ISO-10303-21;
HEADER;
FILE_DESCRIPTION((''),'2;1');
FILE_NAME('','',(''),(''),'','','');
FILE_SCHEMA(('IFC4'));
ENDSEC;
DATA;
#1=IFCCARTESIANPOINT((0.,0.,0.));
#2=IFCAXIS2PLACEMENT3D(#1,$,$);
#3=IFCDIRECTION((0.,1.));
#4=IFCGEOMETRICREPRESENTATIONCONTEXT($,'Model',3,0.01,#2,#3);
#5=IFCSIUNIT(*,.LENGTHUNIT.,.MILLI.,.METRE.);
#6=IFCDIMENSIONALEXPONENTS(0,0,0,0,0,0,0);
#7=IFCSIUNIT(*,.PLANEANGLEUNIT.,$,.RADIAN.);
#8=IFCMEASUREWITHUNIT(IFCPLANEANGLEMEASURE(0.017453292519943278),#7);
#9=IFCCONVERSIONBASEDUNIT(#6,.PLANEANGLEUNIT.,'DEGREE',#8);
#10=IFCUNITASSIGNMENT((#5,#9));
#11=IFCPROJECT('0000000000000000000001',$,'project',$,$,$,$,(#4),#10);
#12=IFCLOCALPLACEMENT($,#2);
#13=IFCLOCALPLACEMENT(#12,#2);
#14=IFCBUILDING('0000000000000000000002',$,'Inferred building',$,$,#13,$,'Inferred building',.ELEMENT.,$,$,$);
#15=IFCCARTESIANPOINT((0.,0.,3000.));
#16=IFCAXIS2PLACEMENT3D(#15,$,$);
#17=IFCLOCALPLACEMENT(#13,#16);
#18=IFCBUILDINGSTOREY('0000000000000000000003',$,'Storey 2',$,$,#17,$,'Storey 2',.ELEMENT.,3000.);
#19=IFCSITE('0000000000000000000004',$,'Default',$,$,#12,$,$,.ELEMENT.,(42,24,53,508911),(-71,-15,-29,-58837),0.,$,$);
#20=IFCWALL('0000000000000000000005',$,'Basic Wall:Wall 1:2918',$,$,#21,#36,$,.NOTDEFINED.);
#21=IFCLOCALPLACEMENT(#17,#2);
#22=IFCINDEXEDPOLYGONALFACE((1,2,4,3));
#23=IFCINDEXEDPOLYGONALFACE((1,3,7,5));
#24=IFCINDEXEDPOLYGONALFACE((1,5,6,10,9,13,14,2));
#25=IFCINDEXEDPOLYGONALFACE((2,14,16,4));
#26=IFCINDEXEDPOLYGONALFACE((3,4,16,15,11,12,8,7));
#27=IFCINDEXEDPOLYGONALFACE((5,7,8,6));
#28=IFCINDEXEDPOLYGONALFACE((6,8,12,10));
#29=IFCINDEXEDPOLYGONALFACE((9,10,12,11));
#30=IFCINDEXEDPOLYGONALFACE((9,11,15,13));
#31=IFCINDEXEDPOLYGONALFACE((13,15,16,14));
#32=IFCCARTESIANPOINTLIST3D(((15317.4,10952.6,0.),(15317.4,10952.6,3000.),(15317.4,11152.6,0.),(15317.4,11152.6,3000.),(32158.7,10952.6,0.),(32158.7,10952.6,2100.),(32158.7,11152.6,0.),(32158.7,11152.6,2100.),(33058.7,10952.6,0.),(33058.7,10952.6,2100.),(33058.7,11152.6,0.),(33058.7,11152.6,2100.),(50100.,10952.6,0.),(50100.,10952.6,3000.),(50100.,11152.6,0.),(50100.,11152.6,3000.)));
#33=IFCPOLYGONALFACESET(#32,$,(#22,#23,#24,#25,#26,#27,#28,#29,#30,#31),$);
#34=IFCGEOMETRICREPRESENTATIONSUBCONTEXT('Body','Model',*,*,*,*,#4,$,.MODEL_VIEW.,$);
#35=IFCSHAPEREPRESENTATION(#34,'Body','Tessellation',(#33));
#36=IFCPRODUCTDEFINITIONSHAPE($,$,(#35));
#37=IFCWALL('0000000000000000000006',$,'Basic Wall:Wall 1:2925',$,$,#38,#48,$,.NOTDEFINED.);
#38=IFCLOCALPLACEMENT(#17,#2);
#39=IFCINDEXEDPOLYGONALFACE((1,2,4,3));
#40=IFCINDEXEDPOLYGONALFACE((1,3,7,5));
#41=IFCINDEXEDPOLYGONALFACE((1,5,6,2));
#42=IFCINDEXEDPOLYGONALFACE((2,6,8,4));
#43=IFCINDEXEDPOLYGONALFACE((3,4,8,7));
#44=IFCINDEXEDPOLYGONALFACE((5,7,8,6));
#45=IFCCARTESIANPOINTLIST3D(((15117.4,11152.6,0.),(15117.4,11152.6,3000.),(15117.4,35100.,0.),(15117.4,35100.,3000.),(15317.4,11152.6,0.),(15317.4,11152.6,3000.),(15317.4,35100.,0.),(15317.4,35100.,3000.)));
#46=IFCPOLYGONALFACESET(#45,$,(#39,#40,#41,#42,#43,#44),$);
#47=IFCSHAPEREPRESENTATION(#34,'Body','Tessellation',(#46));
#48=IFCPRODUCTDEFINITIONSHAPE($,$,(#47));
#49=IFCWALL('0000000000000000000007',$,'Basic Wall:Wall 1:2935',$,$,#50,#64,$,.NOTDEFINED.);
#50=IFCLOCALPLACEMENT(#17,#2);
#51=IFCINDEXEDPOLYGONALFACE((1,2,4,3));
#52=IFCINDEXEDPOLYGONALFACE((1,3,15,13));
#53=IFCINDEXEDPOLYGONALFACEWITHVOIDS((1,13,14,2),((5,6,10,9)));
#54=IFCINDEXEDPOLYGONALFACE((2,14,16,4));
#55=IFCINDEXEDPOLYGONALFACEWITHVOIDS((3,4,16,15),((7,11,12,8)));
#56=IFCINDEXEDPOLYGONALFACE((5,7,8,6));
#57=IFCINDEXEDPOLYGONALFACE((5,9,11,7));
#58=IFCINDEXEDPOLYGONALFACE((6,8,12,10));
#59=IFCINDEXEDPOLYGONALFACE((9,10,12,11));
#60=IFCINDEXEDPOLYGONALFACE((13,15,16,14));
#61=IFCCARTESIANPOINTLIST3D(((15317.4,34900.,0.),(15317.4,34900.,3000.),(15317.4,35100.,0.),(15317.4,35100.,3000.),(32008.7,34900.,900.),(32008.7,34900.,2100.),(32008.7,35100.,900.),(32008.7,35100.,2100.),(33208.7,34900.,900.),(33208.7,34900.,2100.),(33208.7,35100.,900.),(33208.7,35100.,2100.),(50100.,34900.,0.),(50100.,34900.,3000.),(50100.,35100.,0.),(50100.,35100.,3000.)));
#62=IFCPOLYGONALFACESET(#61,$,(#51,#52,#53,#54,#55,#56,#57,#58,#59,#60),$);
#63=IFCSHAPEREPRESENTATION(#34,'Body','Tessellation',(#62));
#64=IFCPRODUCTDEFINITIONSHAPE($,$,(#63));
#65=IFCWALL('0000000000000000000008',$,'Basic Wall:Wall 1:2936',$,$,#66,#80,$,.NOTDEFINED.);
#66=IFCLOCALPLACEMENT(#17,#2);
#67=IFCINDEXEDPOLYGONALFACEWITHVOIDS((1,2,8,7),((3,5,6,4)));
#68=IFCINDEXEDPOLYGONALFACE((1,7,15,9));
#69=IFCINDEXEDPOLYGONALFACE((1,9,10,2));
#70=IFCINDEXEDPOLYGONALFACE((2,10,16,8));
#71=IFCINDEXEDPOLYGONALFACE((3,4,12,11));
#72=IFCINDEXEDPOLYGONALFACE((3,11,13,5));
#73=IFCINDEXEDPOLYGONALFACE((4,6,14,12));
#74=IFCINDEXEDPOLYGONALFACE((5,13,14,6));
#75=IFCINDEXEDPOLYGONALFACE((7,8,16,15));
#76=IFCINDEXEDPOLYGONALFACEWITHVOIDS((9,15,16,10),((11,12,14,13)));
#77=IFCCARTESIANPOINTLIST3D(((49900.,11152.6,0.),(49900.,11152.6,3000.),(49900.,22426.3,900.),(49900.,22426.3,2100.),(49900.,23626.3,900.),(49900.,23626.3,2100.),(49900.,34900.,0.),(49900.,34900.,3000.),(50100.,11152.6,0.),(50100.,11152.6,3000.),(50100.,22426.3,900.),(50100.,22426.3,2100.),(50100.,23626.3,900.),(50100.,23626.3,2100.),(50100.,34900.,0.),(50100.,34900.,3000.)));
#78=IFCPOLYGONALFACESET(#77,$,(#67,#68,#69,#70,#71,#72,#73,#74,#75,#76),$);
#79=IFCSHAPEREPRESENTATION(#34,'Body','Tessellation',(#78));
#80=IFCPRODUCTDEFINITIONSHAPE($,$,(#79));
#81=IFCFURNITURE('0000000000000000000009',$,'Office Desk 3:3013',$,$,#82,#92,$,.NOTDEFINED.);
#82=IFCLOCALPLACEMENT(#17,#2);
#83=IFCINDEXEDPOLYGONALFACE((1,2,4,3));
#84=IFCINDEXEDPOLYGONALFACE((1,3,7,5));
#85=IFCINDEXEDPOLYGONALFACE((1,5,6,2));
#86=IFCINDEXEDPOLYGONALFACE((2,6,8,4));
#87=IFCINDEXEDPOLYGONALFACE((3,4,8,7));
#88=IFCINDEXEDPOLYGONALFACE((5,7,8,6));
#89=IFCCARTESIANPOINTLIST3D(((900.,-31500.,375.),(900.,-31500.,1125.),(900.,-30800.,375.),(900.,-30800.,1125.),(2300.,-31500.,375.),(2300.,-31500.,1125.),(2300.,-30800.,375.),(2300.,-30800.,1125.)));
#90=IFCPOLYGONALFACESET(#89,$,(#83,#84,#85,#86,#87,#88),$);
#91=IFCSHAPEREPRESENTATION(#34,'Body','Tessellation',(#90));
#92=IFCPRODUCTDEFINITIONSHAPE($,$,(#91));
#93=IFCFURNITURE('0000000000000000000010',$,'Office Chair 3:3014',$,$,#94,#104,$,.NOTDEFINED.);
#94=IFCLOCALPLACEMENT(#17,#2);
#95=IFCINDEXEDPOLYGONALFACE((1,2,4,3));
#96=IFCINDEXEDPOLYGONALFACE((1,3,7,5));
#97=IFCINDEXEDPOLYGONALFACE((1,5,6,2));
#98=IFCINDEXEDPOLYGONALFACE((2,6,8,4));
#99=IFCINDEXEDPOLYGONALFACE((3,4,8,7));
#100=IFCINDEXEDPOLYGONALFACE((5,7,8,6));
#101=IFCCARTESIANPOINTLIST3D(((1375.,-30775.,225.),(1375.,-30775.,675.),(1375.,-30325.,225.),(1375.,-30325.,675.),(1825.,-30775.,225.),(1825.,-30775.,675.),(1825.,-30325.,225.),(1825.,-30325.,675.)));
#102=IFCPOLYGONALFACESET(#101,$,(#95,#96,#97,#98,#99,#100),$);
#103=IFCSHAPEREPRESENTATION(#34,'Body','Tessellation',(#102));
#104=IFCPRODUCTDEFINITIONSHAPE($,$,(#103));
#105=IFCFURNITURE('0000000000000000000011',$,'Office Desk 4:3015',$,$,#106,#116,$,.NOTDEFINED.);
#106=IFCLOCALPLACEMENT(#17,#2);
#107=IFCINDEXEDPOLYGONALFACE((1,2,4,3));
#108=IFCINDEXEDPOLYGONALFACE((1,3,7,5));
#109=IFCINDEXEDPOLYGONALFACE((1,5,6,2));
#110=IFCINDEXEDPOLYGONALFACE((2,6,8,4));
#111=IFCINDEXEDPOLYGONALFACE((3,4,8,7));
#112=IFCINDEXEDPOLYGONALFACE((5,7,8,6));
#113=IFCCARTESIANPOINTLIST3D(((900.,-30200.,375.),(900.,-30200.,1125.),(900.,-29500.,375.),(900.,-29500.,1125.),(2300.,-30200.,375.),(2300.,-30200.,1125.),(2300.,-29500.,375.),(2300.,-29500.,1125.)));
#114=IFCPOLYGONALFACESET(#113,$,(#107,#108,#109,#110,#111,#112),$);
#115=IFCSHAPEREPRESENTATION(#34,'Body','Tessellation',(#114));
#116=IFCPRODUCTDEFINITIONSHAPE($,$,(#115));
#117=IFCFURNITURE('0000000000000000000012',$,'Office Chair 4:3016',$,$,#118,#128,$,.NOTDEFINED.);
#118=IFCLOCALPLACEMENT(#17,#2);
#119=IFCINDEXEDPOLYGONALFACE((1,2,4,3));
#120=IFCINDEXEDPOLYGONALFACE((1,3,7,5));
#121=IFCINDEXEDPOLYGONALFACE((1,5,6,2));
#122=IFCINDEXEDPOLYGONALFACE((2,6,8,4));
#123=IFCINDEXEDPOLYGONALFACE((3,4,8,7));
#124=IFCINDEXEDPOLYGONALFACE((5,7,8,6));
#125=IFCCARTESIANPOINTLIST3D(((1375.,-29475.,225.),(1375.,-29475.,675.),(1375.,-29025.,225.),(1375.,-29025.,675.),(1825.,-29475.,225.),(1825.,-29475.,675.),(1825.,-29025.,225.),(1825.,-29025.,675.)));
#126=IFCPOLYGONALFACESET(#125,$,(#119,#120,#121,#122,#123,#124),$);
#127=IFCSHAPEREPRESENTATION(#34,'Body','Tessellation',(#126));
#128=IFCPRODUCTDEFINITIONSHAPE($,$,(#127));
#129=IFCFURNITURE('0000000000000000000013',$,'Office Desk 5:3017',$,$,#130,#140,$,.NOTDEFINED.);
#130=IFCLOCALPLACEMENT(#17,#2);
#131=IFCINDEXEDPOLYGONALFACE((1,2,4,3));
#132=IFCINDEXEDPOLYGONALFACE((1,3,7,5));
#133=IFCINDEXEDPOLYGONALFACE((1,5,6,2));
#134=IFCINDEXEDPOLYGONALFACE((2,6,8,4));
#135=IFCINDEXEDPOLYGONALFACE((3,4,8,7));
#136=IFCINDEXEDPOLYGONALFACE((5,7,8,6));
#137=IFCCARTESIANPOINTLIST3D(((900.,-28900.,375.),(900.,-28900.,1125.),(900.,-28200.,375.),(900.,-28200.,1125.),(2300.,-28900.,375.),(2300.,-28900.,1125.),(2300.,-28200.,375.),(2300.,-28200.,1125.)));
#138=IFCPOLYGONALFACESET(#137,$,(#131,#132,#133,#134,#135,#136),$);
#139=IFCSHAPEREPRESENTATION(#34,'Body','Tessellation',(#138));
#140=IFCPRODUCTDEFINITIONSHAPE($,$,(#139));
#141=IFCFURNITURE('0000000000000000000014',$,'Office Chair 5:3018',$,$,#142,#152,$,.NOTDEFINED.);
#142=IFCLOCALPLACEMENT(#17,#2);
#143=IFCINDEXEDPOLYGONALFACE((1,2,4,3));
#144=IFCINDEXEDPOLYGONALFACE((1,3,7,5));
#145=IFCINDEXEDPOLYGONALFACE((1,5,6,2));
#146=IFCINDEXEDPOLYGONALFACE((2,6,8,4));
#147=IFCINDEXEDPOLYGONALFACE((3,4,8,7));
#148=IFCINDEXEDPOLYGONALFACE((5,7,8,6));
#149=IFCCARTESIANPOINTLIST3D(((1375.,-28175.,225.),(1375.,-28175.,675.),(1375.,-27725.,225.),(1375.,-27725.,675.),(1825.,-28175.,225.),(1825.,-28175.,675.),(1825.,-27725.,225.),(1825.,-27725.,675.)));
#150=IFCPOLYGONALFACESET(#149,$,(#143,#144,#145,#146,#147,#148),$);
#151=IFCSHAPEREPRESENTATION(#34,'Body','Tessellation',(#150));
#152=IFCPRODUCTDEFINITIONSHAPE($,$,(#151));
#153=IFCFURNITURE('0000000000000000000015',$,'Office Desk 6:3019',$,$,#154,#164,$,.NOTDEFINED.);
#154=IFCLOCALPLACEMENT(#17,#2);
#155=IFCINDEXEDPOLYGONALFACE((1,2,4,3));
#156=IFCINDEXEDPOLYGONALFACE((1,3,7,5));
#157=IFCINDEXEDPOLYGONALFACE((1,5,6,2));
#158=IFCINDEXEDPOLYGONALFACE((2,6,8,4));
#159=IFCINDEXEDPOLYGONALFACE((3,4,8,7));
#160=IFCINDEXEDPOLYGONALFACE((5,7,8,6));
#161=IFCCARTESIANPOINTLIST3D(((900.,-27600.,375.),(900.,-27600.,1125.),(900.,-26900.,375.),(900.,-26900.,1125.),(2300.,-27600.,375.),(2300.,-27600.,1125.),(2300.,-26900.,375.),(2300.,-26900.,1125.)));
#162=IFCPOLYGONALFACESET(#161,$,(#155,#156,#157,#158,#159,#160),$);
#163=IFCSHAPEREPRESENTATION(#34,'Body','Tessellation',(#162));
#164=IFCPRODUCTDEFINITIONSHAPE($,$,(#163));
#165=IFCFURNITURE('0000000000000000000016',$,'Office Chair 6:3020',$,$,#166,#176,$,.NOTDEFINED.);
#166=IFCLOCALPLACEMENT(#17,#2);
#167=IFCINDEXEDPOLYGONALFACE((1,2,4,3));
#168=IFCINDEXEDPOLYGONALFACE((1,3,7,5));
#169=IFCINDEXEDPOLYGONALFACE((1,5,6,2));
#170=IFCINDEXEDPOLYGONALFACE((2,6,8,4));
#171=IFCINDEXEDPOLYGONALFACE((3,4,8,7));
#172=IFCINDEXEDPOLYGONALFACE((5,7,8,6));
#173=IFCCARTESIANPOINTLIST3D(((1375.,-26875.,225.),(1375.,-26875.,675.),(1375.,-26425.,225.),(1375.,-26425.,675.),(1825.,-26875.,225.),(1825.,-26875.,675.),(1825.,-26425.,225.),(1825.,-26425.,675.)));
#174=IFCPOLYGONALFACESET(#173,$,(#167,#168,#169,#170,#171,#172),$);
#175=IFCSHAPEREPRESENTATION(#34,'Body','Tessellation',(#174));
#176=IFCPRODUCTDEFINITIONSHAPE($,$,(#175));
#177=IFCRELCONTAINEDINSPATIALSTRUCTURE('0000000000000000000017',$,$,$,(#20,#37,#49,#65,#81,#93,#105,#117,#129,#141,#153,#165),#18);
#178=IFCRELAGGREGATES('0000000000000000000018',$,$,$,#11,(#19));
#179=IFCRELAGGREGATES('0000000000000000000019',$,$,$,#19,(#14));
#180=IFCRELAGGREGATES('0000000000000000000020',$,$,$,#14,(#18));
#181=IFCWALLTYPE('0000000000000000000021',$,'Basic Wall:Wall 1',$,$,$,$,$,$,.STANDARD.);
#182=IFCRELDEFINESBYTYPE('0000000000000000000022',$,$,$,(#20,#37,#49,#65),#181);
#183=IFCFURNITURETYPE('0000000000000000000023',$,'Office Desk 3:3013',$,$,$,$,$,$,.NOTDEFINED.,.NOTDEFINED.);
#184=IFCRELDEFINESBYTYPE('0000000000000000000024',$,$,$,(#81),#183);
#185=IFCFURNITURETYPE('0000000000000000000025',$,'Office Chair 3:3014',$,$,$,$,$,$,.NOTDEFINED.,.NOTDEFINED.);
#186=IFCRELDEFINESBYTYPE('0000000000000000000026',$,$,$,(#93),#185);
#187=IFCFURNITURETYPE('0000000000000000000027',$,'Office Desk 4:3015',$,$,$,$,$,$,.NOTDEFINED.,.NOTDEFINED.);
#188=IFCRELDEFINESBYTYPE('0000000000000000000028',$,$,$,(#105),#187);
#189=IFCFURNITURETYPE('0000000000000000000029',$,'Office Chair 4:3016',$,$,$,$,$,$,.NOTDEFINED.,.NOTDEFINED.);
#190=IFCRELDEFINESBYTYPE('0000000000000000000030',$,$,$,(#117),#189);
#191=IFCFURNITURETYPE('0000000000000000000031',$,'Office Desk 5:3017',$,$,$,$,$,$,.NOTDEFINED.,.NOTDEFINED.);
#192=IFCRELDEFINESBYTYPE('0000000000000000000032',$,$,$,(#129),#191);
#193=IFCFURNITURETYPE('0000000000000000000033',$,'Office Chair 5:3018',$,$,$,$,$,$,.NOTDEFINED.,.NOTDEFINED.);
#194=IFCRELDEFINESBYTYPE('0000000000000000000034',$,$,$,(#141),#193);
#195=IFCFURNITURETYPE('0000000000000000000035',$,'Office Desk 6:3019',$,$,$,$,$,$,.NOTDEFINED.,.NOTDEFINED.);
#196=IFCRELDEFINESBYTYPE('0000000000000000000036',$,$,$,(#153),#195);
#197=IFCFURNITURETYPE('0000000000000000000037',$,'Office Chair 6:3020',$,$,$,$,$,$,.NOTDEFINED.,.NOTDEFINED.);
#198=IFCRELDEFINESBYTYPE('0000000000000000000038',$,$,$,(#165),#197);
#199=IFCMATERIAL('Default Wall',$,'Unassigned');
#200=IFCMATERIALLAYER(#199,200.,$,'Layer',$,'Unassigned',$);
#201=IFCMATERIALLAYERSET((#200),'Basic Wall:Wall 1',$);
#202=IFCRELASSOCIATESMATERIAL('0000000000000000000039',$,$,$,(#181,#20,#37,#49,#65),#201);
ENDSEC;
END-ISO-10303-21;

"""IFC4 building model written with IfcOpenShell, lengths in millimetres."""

from ifc_helpers import new_model, entity, si_unit, converted_unit, direction, frame, frame_2d, origin, origin_2d_with_axis, place, context, subcontext, project, spatial, rectangle, extrude, material, layer, layer_set, layer_usage, type_object, element, save


model = new_model("IFC4")

# Units and contexts
model_context = context("Model", 3, precision=0.01, world=origin(), true_north=direction((0.0, 1.0)))
body_context = subcontext(model_context, "Body", "Model", "MODEL_VIEW")
ifc_project = project(units=[si_unit("LENGTHUNIT", "METRE", prefix="MILLI"), converted_unit("PLANEANGLEUNIT", "DEGREE", entity("IfcPlaneAngleMeasure", 0.017453292519943278), si_unit("PLANEANGLEUNIT", "RADIAN"), dimensions=[0, 0, 0, 0, 0, 0, 0])], contexts=[model_context])

# Site, building, storey
site_placement = place(None, origin())
site = spatial("IfcSite", under=ifc_project, at=site_placement, Name="Default", CompositionType="ELEMENT", RefLatitude=(42, 24, 53, 508911), RefLongitude=(-71, -15, -29, -58837), RefElevation=0.0)
building_placement = place(site_placement, origin())
building = spatial("IfcBuilding", under=site, at=building_placement, Name="Inferred building", LongName="Inferred building", CompositionType="ELEMENT")
storey_placement = place(building_placement, frame((0.0, 0.0, 3000.0)))
storey = spatial("IfcBuildingStorey", under=building, at=storey_placement, Name="Storey 2", LongName="Storey 2", CompositionType="ELEMENT", Elevation=3000.0)

# Wall, opening
ifc_material = material(Name="Default Wall", Category="Unassigned")
ifc_layer = layer(ifc_material, 200.0, Name="Layer", Category="Unassigned")
ifc_layer_set = layer_set([ifc_layer], Name="Basic Wall:Wall 1")
ifc_layer_usage_1 = layer_usage(ifc_layer_set, "AXIS2", "NEGATIVE", 100.0)
wall_type = type_object("IfcWallType", Name="Basic Wall:Wall 1", PredefinedType="STANDARD", material=ifc_layer_set)
wall_1_placement = place(storey_placement, frame((15317.4, 11052.6, 0.0)))
wall_1 = element("IfcWall", 1, at=wall_1_placement, inside=storey, type_object=wall_type, material=ifc_layer_usage_1, Name="Basic Wall:Wall 1:2918", PredefinedType="NOTDEFINED", context=body_context, shape_type="SweptSolid", body=[
    extrude(rectangle(XDim=34782.6, YDim=200.0, at=frame_2d((17391.3, 0.0), x_axis=(1.0, 0.0))), origin(), (0.0, 0.0, 1.0), 3000.0),
])
opening_1_placement = place(wall_1_placement, origin())
element("IfcOpeningElement", 2, at=opening_1_placement, cuts=wall_1, PredefinedType="OPENING", context=body_context, shape_type="SweptSolid", body=[
    extrude(rectangle(XDim=2100.0, YDim=900.0, at=frame_2d((0.0, 0.0), x_axis=(1.0, 0.0))), frame((17291.3, -100.0, 1050.0), z_axis=(0.0, 1.0, 0.0), x_axis=(0.0, 0.0, -1.0)), (0.0, 0.0, 1.0), 200.0),
])

# Wall
ifc_layer_usage_2 = layer_usage(ifc_layer_set, "AXIS2", "NEGATIVE", 100.0)
wall_2_placement = place(storey_placement, frame((15217.4, 11152.6, 0.0), z_axis=(0.0, 0.0, 1.0), x_axis=(0.0, 1.0, 0.0)))
element("IfcWall", 3, at=wall_2_placement, inside=storey, type_object=wall_type, material=ifc_layer_usage_2, Name="Basic Wall:Wall 1:2925", PredefinedType="NOTDEFINED", context=body_context, shape_type="SweptSolid", body=[
    extrude(rectangle(XDim=23947.4, YDim=200.0, at=frame_2d((11973.7, 0.0), x_axis=(-1.0, 0.0))), origin(), (0.0, 0.0, 1.0), 3000.0),
])

# Walls, openings
ifc_layer_usage_3 = layer_usage(ifc_layer_set, "AXIS2", "NEGATIVE", 100.0)
wall_3_placement = place(storey_placement, frame((15317.4, 35000.0, 0.0)))
wall_3 = element("IfcWall", 4, at=wall_3_placement, inside=storey, type_object=wall_type, material=ifc_layer_usage_3, Name="Basic Wall:Wall 1:2935", PredefinedType="NOTDEFINED", context=body_context, shape_type="SweptSolid", body=[
    extrude(rectangle(XDim=34782.6, YDim=200.0, at=frame_2d((17391.3, 0.0), x_axis=(-1.0, 0.0))), origin(), (0.0, 0.0, 1.0), 3000.0),
])
opening_2_placement = place(wall_3_placement, origin())
element("IfcOpeningElement", 5, at=opening_2_placement, cuts=wall_3, PredefinedType="OPENING", context=body_context, shape_type="SweptSolid", body=[
    extrude(rectangle(XDim=1200.0, YDim=1200.0, at=frame_2d((0.0, 0.0), x_axis=(1.0, 0.0))), frame((17291.3, -100.0, 1500.0), z_axis=(0.0, 1.0, 0.0), x_axis=(0.0, 0.0, -1.0)), (0.0, 0.0, 1.0), 200.0),
])
ifc_layer_usage_4 = layer_usage(ifc_layer_set, "AXIS2", "NEGATIVE", 100.0)
wall_4_placement = place(storey_placement, frame((50000.0, 11152.6, 0.0), z_axis=(0.0, 0.0, 1.0), x_axis=(0.0, 1.0, 0.0)))
wall_4 = element("IfcWall", 6, at=wall_4_placement, inside=storey, type_object=wall_type, material=ifc_layer_usage_4, Name="Basic Wall:Wall 1:2936", PredefinedType="NOTDEFINED", context=body_context, shape_type="SweptSolid", body=[
    extrude(rectangle(XDim=23747.4, YDim=200.0, at=frame_2d((11873.7, 0.0), x_axis=(-1.0, 0.0))), origin(), (0.0, 0.0, 1.0), 3000.0),
])
opening_3_placement = place(wall_4_placement, origin())
element("IfcOpeningElement", 7, at=opening_3_placement, cuts=wall_4, PredefinedType="OPENING", context=body_context, shape_type="SweptSolid", body=[
    extrude(rectangle(XDim=1200.0, YDim=1200.0, at=frame_2d((0.0, 0.0), x_axis=(1.0, 0.0))), frame((11873.7, -100.0, 1500.0), z_axis=(0.0, 1.0, 0.0), x_axis=(0.0, 0.0, -1.0)), (0.0, 0.0, 1.0), 200.0),
])

# Furniture
furniture_type_1 = type_object("IfcFurnitureType", Name="Office Desk 3:3013", PredefinedType="NOTDEFINED")
furniture_1_placement = place(storey_placement, origin())
element("IfcFurniture", 8, at=furniture_1_placement, inside=storey, type_object=furniture_type_1, Name="Office Desk 3:3013", PredefinedType="NOTDEFINED", context=body_context, shape_type="SweptSolid", body=[
    extrude(rectangle(XDim=1400.0, YDim=700.0, at=origin_2d_with_axis()), frame((1600.0, -31150.0, 375.0)), (0.0, 0.0, 1.0), 750.0),
])
furniture_type_2 = type_object("IfcFurnitureType", Name="Office Chair 3:3014", PredefinedType="NOTDEFINED")
furniture_2_placement = place(storey_placement, origin())
element("IfcFurniture", 9, at=furniture_2_placement, inside=storey, type_object=furniture_type_2, Name="Office Chair 3:3014", PredefinedType="NOTDEFINED", context=body_context, shape_type="SweptSolid", body=[
    extrude(rectangle(XDim=450.0, YDim=450.0, at=origin_2d_with_axis()), frame((1600.0, -30550.0, 225.0)), (0.0, 0.0, 1.0), 450.0),
])
furniture_type_3 = type_object("IfcFurnitureType", Name="Office Desk 4:3015", PredefinedType="NOTDEFINED")
furniture_3_placement = place(storey_placement, origin())
element("IfcFurniture", 10, at=furniture_3_placement, inside=storey, type_object=furniture_type_3, Name="Office Desk 4:3015", PredefinedType="NOTDEFINED", context=body_context, shape_type="SweptSolid", body=[
    extrude(rectangle(XDim=1400.0, YDim=700.0, at=origin_2d_with_axis()), frame((1600.0, -29850.0, 375.0)), (0.0, 0.0, 1.0), 750.0),
])
furniture_type_4 = type_object("IfcFurnitureType", Name="Office Chair 4:3016", PredefinedType="NOTDEFINED")
furniture_4_placement = place(storey_placement, origin())
element("IfcFurniture", 11, at=furniture_4_placement, inside=storey, type_object=furniture_type_4, Name="Office Chair 4:3016", PredefinedType="NOTDEFINED", context=body_context, shape_type="SweptSolid", body=[
    extrude(rectangle(XDim=450.0, YDim=450.0, at=origin_2d_with_axis()), frame((1600.0, -29250.0, 225.0)), (0.0, 0.0, 1.0), 450.0),
])
furniture_type_5 = type_object("IfcFurnitureType", Name="Office Desk 5:3017", PredefinedType="NOTDEFINED")
furniture_5_placement = place(storey_placement, origin())
element("IfcFurniture", 12, at=furniture_5_placement, inside=storey, type_object=furniture_type_5, Name="Office Desk 5:3017", PredefinedType="NOTDEFINED", context=body_context, shape_type="SweptSolid", body=[
    extrude(rectangle(XDim=1400.0, YDim=700.0, at=origin_2d_with_axis()), frame((1600.0, -28550.0, 375.0)), (0.0, 0.0, 1.0), 750.0),
])
furniture_type_6 = type_object("IfcFurnitureType", Name="Office Chair 5:3018", PredefinedType="NOTDEFINED")
furniture_6_placement = place(storey_placement, origin())
element("IfcFurniture", 13, at=furniture_6_placement, inside=storey, type_object=furniture_type_6, Name="Office Chair 5:3018", PredefinedType="NOTDEFINED", context=body_context, shape_type="SweptSolid", body=[
    extrude(rectangle(XDim=450.0, YDim=450.0, at=origin_2d_with_axis()), frame((1600.0, -27950.0, 225.0)), (0.0, 0.0, 1.0), 450.0),
])
furniture_type_7 = type_object("IfcFurnitureType", Name="Office Desk 6:3019", PredefinedType="NOTDEFINED")
furniture_7_placement = place(storey_placement, origin())
element("IfcFurniture", 14, at=furniture_7_placement, inside=storey, type_object=furniture_type_7, Name="Office Desk 6:3019", PredefinedType="NOTDEFINED", context=body_context, shape_type="SweptSolid", body=[
    extrude(rectangle(XDim=1400.0, YDim=700.0, at=origin_2d_with_axis()), frame((1600.0, -27250.0, 375.0)), (0.0, 0.0, 1.0), 750.0),
])
furniture_type_8 = type_object("IfcFurnitureType", Name="Office Chair 6:3020", PredefinedType="NOTDEFINED")
furniture_8_placement = place(storey_placement, origin())
element("IfcFurniture", 15, at=furniture_8_placement, inside=storey, type_object=furniture_type_8, Name="Office Chair 6:3020", PredefinedType="NOTDEFINED", context=body_context, shape_type="SweptSolid", body=[
    extrude(rectangle(XDim=450.0, YDim=450.0, at=origin_2d_with_axis()), frame((1600.0, -26650.0, 225.0)), (0.0, 0.0, 1.0), 450.0),
])

save(model, "model.ifc")
